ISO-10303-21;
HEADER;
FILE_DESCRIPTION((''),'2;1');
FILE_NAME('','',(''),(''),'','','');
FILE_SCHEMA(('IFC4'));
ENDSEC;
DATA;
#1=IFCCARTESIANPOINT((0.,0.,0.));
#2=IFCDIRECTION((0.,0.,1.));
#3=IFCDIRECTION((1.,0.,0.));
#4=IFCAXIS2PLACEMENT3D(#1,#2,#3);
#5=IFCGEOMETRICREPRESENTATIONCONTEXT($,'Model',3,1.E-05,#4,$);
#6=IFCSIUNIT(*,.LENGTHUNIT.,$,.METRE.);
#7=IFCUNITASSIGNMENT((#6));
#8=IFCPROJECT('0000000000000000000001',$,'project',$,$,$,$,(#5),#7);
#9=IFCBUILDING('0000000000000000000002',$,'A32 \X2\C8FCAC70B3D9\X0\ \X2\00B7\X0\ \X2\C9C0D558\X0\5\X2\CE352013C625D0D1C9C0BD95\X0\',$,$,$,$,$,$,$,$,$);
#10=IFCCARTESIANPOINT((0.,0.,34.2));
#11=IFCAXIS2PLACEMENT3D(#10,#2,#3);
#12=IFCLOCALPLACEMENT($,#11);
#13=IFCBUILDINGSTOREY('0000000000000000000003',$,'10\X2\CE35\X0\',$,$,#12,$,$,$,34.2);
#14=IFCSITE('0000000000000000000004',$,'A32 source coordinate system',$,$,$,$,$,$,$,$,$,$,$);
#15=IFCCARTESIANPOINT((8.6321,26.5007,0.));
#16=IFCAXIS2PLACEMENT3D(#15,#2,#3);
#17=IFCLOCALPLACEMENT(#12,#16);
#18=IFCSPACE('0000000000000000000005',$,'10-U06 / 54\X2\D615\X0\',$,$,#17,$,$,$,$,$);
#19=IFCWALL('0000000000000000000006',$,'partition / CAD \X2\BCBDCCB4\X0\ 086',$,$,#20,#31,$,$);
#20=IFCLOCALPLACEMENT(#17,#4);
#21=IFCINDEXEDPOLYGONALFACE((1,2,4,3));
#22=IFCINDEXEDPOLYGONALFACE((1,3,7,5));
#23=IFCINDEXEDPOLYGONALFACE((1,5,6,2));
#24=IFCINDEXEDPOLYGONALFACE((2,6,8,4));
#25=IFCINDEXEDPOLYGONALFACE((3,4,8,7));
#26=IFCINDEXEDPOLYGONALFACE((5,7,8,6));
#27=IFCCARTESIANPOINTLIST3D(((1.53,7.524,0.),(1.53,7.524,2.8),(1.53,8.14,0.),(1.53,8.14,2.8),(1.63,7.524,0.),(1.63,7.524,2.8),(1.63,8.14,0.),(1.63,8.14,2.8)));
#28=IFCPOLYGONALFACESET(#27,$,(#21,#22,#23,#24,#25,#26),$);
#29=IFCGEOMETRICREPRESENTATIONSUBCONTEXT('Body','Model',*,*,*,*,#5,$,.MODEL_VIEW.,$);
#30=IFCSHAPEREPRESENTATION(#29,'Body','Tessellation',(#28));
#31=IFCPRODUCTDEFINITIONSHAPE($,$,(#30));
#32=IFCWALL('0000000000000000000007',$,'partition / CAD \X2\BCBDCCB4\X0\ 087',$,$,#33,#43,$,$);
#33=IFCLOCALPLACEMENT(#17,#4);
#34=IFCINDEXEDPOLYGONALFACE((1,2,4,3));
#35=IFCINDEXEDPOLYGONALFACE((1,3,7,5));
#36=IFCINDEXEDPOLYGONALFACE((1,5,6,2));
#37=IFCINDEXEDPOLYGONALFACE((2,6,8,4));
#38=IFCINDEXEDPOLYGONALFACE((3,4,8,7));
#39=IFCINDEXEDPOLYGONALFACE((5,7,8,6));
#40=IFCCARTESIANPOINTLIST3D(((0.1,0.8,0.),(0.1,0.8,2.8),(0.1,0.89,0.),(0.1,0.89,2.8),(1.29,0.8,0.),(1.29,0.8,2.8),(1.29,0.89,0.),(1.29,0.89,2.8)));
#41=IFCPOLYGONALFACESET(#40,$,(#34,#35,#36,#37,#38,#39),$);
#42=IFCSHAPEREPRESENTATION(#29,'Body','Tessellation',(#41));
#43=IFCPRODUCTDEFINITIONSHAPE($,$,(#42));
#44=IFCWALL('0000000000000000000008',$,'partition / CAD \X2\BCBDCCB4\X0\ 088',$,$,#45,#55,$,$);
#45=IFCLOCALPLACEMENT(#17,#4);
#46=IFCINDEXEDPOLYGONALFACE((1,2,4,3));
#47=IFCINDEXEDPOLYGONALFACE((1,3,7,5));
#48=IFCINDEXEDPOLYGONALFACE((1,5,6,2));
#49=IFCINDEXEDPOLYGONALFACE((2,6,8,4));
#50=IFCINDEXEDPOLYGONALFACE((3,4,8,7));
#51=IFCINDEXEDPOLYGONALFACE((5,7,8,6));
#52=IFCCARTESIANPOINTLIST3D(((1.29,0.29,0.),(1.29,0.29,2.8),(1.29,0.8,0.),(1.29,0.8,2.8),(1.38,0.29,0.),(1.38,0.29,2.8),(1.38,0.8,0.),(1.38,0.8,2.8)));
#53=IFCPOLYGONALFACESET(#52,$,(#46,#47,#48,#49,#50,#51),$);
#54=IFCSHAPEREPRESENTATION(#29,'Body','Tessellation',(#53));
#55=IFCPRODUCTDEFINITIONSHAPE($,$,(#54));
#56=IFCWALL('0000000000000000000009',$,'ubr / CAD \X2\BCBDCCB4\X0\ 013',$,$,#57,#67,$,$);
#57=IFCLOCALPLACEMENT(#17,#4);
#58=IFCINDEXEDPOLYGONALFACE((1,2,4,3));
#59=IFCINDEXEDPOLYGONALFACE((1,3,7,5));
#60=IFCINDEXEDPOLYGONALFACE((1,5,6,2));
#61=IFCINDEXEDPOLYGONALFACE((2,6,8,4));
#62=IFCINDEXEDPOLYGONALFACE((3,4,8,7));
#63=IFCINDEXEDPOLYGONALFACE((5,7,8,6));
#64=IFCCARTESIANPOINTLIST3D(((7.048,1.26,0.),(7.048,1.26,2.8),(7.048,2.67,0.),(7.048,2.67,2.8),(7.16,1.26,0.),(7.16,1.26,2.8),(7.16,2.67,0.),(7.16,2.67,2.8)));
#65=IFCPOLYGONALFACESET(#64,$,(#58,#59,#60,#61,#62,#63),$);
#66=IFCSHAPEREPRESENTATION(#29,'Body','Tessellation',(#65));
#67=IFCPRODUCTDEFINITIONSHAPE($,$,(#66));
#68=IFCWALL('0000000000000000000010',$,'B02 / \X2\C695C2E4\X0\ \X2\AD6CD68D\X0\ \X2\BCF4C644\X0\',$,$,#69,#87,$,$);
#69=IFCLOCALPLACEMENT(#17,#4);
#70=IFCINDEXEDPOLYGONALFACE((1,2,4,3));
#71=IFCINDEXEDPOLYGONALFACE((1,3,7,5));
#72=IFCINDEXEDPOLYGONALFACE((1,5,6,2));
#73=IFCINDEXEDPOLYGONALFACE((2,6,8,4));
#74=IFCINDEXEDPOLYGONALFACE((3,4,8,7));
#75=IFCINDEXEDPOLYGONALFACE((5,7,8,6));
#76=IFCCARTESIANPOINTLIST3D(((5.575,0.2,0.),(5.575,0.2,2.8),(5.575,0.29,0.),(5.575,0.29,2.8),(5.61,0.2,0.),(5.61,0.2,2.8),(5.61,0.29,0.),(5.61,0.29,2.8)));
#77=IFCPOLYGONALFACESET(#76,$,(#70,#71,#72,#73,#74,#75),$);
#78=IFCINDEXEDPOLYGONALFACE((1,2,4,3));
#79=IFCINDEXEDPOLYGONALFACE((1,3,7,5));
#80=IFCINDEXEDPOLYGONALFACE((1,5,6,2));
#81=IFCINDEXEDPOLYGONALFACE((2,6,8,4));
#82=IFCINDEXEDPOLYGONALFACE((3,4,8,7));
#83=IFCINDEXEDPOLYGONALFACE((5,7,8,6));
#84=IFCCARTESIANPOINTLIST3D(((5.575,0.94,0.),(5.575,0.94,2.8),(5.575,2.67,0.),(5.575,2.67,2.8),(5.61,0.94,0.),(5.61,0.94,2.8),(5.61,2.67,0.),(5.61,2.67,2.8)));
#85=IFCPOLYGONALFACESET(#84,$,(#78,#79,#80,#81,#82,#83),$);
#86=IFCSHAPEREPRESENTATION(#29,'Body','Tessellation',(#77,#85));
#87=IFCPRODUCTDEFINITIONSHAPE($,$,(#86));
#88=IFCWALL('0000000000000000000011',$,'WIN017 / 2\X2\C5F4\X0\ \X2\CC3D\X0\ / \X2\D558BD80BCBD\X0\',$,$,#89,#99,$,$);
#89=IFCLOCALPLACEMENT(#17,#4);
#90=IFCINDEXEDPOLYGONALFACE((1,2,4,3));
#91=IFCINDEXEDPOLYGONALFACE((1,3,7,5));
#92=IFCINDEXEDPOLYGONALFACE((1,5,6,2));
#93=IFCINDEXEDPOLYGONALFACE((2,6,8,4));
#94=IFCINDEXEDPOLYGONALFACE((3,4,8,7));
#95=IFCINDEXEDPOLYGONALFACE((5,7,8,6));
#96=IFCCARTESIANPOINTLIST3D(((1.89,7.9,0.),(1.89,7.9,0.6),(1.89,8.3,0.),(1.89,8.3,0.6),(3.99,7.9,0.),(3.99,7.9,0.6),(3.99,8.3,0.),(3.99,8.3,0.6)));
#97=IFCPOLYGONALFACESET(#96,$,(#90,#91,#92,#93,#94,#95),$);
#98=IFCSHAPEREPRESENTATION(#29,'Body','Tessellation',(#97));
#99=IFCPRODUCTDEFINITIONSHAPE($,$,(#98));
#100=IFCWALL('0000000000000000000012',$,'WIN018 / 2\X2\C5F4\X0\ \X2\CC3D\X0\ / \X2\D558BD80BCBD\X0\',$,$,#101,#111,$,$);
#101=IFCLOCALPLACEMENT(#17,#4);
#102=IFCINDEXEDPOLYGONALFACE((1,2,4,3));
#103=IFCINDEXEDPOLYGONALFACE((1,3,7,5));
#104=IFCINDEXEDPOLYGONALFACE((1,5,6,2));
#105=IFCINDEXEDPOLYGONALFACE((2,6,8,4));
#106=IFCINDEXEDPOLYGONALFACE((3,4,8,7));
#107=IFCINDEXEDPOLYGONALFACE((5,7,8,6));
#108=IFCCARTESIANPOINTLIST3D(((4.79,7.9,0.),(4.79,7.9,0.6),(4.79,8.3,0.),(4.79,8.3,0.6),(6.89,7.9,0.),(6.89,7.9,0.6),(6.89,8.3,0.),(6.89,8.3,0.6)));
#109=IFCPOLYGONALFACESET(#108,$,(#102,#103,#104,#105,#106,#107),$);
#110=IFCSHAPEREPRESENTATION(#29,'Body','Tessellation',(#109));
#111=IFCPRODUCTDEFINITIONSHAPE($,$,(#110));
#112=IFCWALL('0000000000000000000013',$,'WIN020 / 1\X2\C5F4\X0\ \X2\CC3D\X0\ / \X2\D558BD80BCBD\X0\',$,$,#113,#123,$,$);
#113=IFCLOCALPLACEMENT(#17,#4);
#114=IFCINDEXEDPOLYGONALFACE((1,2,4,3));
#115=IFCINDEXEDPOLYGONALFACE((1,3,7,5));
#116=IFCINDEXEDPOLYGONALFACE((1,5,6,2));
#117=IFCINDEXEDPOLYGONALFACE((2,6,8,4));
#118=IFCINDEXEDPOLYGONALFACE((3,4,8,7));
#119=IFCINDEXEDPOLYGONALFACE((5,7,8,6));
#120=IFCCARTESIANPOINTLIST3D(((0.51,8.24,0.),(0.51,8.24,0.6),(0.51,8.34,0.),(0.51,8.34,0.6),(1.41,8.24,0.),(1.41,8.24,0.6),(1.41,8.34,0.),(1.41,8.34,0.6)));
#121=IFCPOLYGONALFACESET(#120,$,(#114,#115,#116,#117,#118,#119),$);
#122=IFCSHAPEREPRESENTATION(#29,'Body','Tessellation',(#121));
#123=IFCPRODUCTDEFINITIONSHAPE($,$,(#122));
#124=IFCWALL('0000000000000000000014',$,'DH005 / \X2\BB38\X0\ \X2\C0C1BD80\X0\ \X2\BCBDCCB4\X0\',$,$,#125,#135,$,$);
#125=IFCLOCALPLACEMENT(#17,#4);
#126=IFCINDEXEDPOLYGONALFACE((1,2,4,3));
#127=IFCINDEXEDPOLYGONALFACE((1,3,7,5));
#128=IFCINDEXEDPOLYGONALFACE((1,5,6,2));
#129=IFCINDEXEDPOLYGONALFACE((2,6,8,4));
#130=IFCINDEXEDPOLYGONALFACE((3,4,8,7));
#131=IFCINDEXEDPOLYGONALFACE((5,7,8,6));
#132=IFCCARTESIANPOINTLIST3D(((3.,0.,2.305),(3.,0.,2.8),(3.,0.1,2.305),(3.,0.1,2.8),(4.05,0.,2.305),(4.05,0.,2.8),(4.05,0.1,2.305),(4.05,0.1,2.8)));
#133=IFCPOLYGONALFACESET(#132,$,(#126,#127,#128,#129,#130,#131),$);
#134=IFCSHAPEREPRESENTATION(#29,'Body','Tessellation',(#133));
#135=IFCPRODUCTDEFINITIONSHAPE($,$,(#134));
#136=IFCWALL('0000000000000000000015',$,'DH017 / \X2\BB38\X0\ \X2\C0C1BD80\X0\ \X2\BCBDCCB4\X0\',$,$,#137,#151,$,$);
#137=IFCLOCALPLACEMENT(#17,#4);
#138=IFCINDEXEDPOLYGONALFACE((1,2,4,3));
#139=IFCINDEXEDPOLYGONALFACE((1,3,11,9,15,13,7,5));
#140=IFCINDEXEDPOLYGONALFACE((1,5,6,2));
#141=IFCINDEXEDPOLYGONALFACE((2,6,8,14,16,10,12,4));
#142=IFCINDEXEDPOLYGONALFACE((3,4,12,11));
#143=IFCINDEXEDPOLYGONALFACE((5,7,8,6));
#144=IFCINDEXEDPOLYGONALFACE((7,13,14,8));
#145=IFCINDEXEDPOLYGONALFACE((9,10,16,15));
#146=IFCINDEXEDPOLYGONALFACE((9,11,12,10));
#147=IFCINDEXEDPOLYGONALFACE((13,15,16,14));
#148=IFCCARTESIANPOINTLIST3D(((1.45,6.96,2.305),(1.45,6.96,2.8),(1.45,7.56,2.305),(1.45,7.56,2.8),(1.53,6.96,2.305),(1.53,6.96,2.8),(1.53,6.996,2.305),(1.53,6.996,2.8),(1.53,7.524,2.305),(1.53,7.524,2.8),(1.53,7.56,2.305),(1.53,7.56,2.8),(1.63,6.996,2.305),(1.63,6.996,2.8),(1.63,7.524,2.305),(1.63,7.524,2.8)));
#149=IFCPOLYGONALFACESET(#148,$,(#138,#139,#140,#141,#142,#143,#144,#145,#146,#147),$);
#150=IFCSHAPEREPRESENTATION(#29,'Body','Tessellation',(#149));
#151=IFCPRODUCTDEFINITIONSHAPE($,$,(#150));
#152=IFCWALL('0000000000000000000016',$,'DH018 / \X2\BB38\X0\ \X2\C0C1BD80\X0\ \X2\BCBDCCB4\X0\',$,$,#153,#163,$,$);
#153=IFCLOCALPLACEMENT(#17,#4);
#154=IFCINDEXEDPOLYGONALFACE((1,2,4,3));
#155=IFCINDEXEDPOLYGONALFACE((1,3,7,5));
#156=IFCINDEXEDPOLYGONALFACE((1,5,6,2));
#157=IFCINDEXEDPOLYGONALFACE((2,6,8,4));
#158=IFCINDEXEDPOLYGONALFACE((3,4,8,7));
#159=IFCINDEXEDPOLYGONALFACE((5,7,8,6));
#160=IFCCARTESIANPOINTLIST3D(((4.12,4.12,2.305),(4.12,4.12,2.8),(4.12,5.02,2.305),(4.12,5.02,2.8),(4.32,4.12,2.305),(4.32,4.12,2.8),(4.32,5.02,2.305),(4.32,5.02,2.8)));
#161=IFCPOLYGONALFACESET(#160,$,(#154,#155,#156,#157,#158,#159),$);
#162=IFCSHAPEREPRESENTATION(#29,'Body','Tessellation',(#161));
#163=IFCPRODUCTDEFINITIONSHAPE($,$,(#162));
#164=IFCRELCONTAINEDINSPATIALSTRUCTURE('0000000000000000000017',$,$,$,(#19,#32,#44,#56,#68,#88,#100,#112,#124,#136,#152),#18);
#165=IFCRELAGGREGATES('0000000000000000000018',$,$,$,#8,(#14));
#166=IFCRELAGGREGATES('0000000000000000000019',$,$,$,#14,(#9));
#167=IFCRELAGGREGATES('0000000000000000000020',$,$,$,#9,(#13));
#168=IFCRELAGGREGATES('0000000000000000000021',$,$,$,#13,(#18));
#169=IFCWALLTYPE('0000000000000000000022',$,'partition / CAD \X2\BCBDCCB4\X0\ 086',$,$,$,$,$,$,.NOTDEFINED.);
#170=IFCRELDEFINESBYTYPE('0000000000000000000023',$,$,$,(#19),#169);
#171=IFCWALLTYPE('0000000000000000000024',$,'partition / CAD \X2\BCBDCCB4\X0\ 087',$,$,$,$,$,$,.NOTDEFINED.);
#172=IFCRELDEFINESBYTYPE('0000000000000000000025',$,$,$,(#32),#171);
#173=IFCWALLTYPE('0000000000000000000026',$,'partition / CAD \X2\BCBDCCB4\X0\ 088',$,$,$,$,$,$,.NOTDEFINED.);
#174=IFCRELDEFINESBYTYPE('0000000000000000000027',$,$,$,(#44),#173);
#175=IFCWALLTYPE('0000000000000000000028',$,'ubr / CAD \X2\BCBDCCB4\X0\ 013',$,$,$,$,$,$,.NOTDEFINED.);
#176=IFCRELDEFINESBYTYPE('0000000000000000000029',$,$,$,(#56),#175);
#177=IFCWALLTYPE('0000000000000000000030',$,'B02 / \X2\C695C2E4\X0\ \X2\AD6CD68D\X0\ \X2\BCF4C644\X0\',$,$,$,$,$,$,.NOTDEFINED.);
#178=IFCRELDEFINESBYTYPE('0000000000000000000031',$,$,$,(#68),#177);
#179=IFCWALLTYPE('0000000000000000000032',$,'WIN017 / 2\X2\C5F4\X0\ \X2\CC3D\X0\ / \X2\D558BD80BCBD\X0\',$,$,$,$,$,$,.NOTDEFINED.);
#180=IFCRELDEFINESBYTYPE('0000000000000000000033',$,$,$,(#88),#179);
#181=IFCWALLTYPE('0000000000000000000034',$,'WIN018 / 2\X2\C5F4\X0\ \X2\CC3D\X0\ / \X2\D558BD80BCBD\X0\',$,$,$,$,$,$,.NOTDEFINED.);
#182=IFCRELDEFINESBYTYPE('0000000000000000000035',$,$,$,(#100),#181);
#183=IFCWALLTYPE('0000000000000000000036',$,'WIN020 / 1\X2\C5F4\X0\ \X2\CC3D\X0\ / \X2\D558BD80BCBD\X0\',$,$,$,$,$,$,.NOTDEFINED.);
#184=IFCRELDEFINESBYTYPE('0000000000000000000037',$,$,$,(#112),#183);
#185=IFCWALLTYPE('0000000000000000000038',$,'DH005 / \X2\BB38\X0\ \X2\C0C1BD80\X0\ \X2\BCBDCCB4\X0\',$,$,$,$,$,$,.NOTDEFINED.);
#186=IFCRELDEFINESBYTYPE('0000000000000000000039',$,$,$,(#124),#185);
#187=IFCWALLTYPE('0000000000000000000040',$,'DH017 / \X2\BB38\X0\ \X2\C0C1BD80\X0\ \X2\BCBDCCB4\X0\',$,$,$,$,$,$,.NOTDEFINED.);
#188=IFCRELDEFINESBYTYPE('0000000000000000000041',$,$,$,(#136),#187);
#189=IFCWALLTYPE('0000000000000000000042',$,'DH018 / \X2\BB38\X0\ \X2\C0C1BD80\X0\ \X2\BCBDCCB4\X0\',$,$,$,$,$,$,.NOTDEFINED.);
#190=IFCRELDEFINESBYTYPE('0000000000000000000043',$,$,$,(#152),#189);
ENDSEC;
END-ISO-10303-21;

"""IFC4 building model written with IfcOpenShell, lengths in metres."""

from ifc_helpers import new_model, si_unit, frame, origin, origin_with_axes, place, context, subcontext, project, spatial, polyline, outline, extrude, source, transform, mapped, type_object, type_shapes, element, save


model = new_model("IFC4")

# Units and contexts
model_context = context("Model", 3, precision=1e-05, world=origin_with_axes())
body_context = subcontext(model_context, "Body", "Model", "MODEL_VIEW")
ifc_project = project(units=[si_unit("LENGTHUNIT", "METRE")], contexts=[model_context])

# Site, building, storey, space
site = spatial("IfcSite", under=ifc_project, Name="A32 source coordinate system")
building = spatial("IfcBuilding", under=site, Name="A32 주거동 · 지하5층–옥탑지붕")
storey_placement = place(None, frame((0.0, 0.0, 34.2), z_axis=(0.0, 0.0, 1.0), x_axis=(1.0, 0.0, 0.0)))
storey = spatial("IfcBuildingStorey", under=building, at=storey_placement, Name="10층", Elevation=34.2)
space_placement = place(storey_placement, frame((8.6321, 26.5007, 0.0), z_axis=(0.0, 0.0, 1.0), x_axis=(1.0, 0.0, 0.0)))
space = spatial("IfcSpace", under=storey, at=space_placement, Name="10-U06 / 54형")

# Walls
wall_type_1 = type_object("IfcWallType", Name="partition / CAD 벽체 086", PredefinedType="NOTDEFINED")
shared_shape_1 = source(origin(), body_context, "Body", "SweptSolid", [
    extrude(outline(polyline([(1.53, 7.524), (1.53, 8.14), (1.63, 8.14), (1.63, 7.524), (1.53, 7.524)])), origin(), (0.0, 0.0, 1.0), 2.8),
])
type_shapes(wall_type_1, [shared_shape_1])
wall_1_placement = place(space_placement, origin_with_axes())
element("IfcWall", 1, at=wall_1_placement, inside=space, type_object=wall_type_1, Name="partition / CAD 벽체 086", context=body_context, shape_type="MappedRepresentation", body=[
    mapped(shared_shape_1, transform((0.0, 0.0, 0.0), scale=1.0)),
])
wall_type_2 = type_object("IfcWallType", Name="partition / CAD 벽체 087", PredefinedType="NOTDEFINED")
shared_shape_2 = source(origin(), body_context, "Body", "SweptSolid", [
    extrude(outline(polyline([(1.29, 0.8), (0.1, 0.8), (0.1, 0.89), (1.29, 0.89), (1.29, 0.8)])), origin(), (0.0, 0.0, 1.0), 2.8),
])
type_shapes(wall_type_2, [shared_shape_2])
wall_2_placement = place(space_placement, origin_with_axes())
element("IfcWall", 2, at=wall_2_placement, inside=space, type_object=wall_type_2, Name="partition / CAD 벽체 087", context=body_context, shape_type="MappedRepresentation", body=[
    mapped(shared_shape_2, transform((0.0, 0.0, 0.0), scale=1.0)),
])
wall_type_3 = type_object("IfcWallType", Name="partition / CAD 벽체 088", PredefinedType="NOTDEFINED")
shared_shape_3 = source(origin(), body_context, "Body", "SweptSolid", [
    extrude(outline(polyline([(1.29, 0.29), (1.29, 0.8), (1.38, 0.8), (1.38, 0.29), (1.29, 0.29)])), origin(), (0.0, 0.0, 1.0), 2.8),
])
type_shapes(wall_type_3, [shared_shape_3])
wall_3_placement = place(space_placement, origin_with_axes())
element("IfcWall", 3, at=wall_3_placement, inside=space, type_object=wall_type_3, Name="partition / CAD 벽체 088", context=body_context, shape_type="MappedRepresentation", body=[
    mapped(shared_shape_3, transform((0.0, 0.0, 0.0), scale=1.0)),
])
wall_type_4 = type_object("IfcWallType", Name="ubr / CAD 벽체 013", PredefinedType="NOTDEFINED")
shared_shape_4 = source(origin(), body_context, "Body", "SweptSolid", [
    extrude(outline(polyline([(7.16, 1.26), (7.048, 1.26), (7.048, 2.67), (7.16, 2.67), (7.16, 1.26)])), origin(), (0.0, 0.0, 1.0), 2.8),
])
type_shapes(wall_type_4, [shared_shape_4])
wall_4_placement = place(space_placement, origin_with_axes())
element("IfcWall", 4, at=wall_4_placement, inside=space, type_object=wall_type_4, Name="ubr / CAD 벽체 013", context=body_context, shape_type="MappedRepresentation", body=[
    mapped(shared_shape_4, transform((0.0, 0.0, 0.0), scale=1.0)),
])
wall_type_5 = type_object("IfcWallType", Name="B02 / 욕실 구획 보완", PredefinedType="NOTDEFINED")
shared_shape_5 = source(origin(), body_context, "Body", "SweptSolid", [
    extrude(outline(polyline([(5.575, 0.2), (5.575, 0.29), (5.61, 0.29), (5.61, 0.2), (5.575, 0.2)])), origin(), (0.0, 0.0, 1.0), 2.8),
    extrude(outline(polyline([(5.575, 0.94), (5.575, 2.67), (5.61, 2.67), (5.61, 0.94), (5.575, 0.94)])), origin(), (0.0, 0.0, 1.0), 2.8),
])
type_shapes(wall_type_5, [shared_shape_5])
wall_5_placement = place(space_placement, origin_with_axes())
element("IfcWall", 5, at=wall_5_placement, inside=space, type_object=wall_type_5, Name="B02 / 욕실 구획 보완", context=body_context, shape_type="MappedRepresentation", body=[
    mapped(shared_shape_5, transform((0.0, 0.0, 0.0), scale=1.0)),
])
wall_type_6 = type_object("IfcWallType", Name="WIN017 / 2열 창 / 하부벽", PredefinedType="NOTDEFINED")
shared_shape_6 = source(origin(), body_context, "Body", "SweptSolid", [
    extrude(outline(polyline([(3.99, 8.3), (3.99, 7.9), (1.89, 7.9), (1.89, 8.3), (3.99, 8.3)])), origin(), (0.0, 0.0, 1.0), 0.6),
])
type_shapes(wall_type_6, [shared_shape_6])
wall_6_placement = place(space_placement, origin_with_axes())
element("IfcWall", 6, at=wall_6_placement, inside=space, type_object=wall_type_6, Name="WIN017 / 2열 창 / 하부벽", context=body_context, shape_type="MappedRepresentation", body=[
    mapped(shared_shape_6, transform((0.0, 0.0, 0.0), scale=1.0)),
])
wall_type_7 = type_object("IfcWallType", Name="WIN018 / 2열 창 / 하부벽", PredefinedType="NOTDEFINED")
shared_shape_7 = source(origin(), body_context, "Body", "SweptSolid", [
    extrude(outline(polyline([(6.89, 8.3), (6.89, 7.9), (4.79, 7.9), (4.79, 8.3), (6.89, 8.3)])), origin(), (0.0, 0.0, 1.0), 0.6),
])
type_shapes(wall_type_7, [shared_shape_7])
wall_7_placement = place(space_placement, origin_with_axes())
element("IfcWall", 7, at=wall_7_placement, inside=space, type_object=wall_type_7, Name="WIN018 / 2열 창 / 하부벽", context=body_context, shape_type="MappedRepresentation", body=[
    mapped(shared_shape_7, transform((0.0, 0.0, 0.0), scale=1.0)),
])
wall_type_8 = type_object("IfcWallType", Name="WIN020 / 1열 창 / 하부벽", PredefinedType="NOTDEFINED")
shared_shape_8 = source(origin(), body_context, "Body", "SweptSolid", [
    extrude(outline(polyline([(1.41, 8.34), (1.41, 8.24), (0.51, 8.24), (0.51, 8.34), (1.41, 8.34)])), origin(), (0.0, 0.0, 1.0), 0.6),
])
type_shapes(wall_type_8, [shared_shape_8])
wall_8_placement = place(space_placement, origin_with_axes())
element("IfcWall", 8, at=wall_8_placement, inside=space, type_object=wall_type_8, Name="WIN020 / 1열 창 / 하부벽", context=body_context, shape_type="MappedRepresentation", body=[
    mapped(shared_shape_8, transform((0.0, 0.0, 0.0), scale=1.0)),
])
wall_type_9 = type_object("IfcWallType", Name="DH005 / 문 상부 벽체", PredefinedType="NOTDEFINED")
shared_shape_9 = source(origin(), body_context, "Body", "SweptSolid", [
    extrude(outline(polyline([(4.05, 0.0), (3.0, 0.0), (3.0, 0.1), (4.05, 0.1), (4.05, 0.0)])), frame((0.0, 0.0, 2.305)), (0.0, 0.0, 1.0), 0.495),
])
type_shapes(wall_type_9, [shared_shape_9])
wall_9_placement = place(space_placement, origin_with_axes())
element("IfcWall", 9, at=wall_9_placement, inside=space, type_object=wall_type_9, Name="DH005 / 문 상부 벽체", context=body_context, shape_type="MappedRepresentation", body=[
    mapped(shared_shape_9, transform((0.0, 0.0, 0.0), scale=1.0)),
])
wall_type_10 = type_object("IfcWallType", Name="DH017 / 문 상부 벽체", PredefinedType="NOTDEFINED")
shared_shape_10 = source(origin(), body_context, "Body", "SweptSolid", [
    extrude(outline(polyline([(1.63, 7.524), (1.63, 6.996), (1.53, 6.996), (1.53, 6.96), (1.45, 6.96), (1.45, 7.56), (1.53, 7.56), (1.53, 7.524), (1.63, 7.524)])), frame((0.0, 0.0, 2.305)), (0.0, 0.0, 1.0), 0.495),
])
type_shapes(wall_type_10, [shared_shape_10])
wall_10_placement = place(space_placement, origin_with_axes())
element("IfcWall", 10, at=wall_10_placement, inside=space, type_object=wall_type_10, Name="DH017 / 문 상부 벽체", context=body_context, shape_type="MappedRepresentation", body=[
    mapped(shared_shape_10, transform((0.0, 0.0, 0.0), scale=1.0)),
])
wall_type_11 = type_object("IfcWallType", Name="DH018 / 문 상부 벽체", PredefinedType="NOTDEFINED")
shared_shape_11 = source(origin(), body_context, "Body", "SweptSolid", [
    extrude(outline(polyline([(4.32, 4.12), (4.12, 4.12), (4.12, 5.02), (4.32, 5.02), (4.32, 4.12)])), frame((0.0, 0.0, 2.305)), (0.0, 0.0, 1.0), 0.495),
])
type_shapes(wall_type_11, [shared_shape_11])
wall_11_placement = place(space_placement, origin_with_axes())
element("IfcWall", 11, at=wall_11_placement, inside=space, type_object=wall_type_11, Name="DH018 / 문 상부 벽체", context=body_context, shape_type="MappedRepresentation", body=[
    mapped(shared_shape_11, transform((0.0, 0.0, 0.0), scale=1.0)),
])

save(model, "model.ifc")
